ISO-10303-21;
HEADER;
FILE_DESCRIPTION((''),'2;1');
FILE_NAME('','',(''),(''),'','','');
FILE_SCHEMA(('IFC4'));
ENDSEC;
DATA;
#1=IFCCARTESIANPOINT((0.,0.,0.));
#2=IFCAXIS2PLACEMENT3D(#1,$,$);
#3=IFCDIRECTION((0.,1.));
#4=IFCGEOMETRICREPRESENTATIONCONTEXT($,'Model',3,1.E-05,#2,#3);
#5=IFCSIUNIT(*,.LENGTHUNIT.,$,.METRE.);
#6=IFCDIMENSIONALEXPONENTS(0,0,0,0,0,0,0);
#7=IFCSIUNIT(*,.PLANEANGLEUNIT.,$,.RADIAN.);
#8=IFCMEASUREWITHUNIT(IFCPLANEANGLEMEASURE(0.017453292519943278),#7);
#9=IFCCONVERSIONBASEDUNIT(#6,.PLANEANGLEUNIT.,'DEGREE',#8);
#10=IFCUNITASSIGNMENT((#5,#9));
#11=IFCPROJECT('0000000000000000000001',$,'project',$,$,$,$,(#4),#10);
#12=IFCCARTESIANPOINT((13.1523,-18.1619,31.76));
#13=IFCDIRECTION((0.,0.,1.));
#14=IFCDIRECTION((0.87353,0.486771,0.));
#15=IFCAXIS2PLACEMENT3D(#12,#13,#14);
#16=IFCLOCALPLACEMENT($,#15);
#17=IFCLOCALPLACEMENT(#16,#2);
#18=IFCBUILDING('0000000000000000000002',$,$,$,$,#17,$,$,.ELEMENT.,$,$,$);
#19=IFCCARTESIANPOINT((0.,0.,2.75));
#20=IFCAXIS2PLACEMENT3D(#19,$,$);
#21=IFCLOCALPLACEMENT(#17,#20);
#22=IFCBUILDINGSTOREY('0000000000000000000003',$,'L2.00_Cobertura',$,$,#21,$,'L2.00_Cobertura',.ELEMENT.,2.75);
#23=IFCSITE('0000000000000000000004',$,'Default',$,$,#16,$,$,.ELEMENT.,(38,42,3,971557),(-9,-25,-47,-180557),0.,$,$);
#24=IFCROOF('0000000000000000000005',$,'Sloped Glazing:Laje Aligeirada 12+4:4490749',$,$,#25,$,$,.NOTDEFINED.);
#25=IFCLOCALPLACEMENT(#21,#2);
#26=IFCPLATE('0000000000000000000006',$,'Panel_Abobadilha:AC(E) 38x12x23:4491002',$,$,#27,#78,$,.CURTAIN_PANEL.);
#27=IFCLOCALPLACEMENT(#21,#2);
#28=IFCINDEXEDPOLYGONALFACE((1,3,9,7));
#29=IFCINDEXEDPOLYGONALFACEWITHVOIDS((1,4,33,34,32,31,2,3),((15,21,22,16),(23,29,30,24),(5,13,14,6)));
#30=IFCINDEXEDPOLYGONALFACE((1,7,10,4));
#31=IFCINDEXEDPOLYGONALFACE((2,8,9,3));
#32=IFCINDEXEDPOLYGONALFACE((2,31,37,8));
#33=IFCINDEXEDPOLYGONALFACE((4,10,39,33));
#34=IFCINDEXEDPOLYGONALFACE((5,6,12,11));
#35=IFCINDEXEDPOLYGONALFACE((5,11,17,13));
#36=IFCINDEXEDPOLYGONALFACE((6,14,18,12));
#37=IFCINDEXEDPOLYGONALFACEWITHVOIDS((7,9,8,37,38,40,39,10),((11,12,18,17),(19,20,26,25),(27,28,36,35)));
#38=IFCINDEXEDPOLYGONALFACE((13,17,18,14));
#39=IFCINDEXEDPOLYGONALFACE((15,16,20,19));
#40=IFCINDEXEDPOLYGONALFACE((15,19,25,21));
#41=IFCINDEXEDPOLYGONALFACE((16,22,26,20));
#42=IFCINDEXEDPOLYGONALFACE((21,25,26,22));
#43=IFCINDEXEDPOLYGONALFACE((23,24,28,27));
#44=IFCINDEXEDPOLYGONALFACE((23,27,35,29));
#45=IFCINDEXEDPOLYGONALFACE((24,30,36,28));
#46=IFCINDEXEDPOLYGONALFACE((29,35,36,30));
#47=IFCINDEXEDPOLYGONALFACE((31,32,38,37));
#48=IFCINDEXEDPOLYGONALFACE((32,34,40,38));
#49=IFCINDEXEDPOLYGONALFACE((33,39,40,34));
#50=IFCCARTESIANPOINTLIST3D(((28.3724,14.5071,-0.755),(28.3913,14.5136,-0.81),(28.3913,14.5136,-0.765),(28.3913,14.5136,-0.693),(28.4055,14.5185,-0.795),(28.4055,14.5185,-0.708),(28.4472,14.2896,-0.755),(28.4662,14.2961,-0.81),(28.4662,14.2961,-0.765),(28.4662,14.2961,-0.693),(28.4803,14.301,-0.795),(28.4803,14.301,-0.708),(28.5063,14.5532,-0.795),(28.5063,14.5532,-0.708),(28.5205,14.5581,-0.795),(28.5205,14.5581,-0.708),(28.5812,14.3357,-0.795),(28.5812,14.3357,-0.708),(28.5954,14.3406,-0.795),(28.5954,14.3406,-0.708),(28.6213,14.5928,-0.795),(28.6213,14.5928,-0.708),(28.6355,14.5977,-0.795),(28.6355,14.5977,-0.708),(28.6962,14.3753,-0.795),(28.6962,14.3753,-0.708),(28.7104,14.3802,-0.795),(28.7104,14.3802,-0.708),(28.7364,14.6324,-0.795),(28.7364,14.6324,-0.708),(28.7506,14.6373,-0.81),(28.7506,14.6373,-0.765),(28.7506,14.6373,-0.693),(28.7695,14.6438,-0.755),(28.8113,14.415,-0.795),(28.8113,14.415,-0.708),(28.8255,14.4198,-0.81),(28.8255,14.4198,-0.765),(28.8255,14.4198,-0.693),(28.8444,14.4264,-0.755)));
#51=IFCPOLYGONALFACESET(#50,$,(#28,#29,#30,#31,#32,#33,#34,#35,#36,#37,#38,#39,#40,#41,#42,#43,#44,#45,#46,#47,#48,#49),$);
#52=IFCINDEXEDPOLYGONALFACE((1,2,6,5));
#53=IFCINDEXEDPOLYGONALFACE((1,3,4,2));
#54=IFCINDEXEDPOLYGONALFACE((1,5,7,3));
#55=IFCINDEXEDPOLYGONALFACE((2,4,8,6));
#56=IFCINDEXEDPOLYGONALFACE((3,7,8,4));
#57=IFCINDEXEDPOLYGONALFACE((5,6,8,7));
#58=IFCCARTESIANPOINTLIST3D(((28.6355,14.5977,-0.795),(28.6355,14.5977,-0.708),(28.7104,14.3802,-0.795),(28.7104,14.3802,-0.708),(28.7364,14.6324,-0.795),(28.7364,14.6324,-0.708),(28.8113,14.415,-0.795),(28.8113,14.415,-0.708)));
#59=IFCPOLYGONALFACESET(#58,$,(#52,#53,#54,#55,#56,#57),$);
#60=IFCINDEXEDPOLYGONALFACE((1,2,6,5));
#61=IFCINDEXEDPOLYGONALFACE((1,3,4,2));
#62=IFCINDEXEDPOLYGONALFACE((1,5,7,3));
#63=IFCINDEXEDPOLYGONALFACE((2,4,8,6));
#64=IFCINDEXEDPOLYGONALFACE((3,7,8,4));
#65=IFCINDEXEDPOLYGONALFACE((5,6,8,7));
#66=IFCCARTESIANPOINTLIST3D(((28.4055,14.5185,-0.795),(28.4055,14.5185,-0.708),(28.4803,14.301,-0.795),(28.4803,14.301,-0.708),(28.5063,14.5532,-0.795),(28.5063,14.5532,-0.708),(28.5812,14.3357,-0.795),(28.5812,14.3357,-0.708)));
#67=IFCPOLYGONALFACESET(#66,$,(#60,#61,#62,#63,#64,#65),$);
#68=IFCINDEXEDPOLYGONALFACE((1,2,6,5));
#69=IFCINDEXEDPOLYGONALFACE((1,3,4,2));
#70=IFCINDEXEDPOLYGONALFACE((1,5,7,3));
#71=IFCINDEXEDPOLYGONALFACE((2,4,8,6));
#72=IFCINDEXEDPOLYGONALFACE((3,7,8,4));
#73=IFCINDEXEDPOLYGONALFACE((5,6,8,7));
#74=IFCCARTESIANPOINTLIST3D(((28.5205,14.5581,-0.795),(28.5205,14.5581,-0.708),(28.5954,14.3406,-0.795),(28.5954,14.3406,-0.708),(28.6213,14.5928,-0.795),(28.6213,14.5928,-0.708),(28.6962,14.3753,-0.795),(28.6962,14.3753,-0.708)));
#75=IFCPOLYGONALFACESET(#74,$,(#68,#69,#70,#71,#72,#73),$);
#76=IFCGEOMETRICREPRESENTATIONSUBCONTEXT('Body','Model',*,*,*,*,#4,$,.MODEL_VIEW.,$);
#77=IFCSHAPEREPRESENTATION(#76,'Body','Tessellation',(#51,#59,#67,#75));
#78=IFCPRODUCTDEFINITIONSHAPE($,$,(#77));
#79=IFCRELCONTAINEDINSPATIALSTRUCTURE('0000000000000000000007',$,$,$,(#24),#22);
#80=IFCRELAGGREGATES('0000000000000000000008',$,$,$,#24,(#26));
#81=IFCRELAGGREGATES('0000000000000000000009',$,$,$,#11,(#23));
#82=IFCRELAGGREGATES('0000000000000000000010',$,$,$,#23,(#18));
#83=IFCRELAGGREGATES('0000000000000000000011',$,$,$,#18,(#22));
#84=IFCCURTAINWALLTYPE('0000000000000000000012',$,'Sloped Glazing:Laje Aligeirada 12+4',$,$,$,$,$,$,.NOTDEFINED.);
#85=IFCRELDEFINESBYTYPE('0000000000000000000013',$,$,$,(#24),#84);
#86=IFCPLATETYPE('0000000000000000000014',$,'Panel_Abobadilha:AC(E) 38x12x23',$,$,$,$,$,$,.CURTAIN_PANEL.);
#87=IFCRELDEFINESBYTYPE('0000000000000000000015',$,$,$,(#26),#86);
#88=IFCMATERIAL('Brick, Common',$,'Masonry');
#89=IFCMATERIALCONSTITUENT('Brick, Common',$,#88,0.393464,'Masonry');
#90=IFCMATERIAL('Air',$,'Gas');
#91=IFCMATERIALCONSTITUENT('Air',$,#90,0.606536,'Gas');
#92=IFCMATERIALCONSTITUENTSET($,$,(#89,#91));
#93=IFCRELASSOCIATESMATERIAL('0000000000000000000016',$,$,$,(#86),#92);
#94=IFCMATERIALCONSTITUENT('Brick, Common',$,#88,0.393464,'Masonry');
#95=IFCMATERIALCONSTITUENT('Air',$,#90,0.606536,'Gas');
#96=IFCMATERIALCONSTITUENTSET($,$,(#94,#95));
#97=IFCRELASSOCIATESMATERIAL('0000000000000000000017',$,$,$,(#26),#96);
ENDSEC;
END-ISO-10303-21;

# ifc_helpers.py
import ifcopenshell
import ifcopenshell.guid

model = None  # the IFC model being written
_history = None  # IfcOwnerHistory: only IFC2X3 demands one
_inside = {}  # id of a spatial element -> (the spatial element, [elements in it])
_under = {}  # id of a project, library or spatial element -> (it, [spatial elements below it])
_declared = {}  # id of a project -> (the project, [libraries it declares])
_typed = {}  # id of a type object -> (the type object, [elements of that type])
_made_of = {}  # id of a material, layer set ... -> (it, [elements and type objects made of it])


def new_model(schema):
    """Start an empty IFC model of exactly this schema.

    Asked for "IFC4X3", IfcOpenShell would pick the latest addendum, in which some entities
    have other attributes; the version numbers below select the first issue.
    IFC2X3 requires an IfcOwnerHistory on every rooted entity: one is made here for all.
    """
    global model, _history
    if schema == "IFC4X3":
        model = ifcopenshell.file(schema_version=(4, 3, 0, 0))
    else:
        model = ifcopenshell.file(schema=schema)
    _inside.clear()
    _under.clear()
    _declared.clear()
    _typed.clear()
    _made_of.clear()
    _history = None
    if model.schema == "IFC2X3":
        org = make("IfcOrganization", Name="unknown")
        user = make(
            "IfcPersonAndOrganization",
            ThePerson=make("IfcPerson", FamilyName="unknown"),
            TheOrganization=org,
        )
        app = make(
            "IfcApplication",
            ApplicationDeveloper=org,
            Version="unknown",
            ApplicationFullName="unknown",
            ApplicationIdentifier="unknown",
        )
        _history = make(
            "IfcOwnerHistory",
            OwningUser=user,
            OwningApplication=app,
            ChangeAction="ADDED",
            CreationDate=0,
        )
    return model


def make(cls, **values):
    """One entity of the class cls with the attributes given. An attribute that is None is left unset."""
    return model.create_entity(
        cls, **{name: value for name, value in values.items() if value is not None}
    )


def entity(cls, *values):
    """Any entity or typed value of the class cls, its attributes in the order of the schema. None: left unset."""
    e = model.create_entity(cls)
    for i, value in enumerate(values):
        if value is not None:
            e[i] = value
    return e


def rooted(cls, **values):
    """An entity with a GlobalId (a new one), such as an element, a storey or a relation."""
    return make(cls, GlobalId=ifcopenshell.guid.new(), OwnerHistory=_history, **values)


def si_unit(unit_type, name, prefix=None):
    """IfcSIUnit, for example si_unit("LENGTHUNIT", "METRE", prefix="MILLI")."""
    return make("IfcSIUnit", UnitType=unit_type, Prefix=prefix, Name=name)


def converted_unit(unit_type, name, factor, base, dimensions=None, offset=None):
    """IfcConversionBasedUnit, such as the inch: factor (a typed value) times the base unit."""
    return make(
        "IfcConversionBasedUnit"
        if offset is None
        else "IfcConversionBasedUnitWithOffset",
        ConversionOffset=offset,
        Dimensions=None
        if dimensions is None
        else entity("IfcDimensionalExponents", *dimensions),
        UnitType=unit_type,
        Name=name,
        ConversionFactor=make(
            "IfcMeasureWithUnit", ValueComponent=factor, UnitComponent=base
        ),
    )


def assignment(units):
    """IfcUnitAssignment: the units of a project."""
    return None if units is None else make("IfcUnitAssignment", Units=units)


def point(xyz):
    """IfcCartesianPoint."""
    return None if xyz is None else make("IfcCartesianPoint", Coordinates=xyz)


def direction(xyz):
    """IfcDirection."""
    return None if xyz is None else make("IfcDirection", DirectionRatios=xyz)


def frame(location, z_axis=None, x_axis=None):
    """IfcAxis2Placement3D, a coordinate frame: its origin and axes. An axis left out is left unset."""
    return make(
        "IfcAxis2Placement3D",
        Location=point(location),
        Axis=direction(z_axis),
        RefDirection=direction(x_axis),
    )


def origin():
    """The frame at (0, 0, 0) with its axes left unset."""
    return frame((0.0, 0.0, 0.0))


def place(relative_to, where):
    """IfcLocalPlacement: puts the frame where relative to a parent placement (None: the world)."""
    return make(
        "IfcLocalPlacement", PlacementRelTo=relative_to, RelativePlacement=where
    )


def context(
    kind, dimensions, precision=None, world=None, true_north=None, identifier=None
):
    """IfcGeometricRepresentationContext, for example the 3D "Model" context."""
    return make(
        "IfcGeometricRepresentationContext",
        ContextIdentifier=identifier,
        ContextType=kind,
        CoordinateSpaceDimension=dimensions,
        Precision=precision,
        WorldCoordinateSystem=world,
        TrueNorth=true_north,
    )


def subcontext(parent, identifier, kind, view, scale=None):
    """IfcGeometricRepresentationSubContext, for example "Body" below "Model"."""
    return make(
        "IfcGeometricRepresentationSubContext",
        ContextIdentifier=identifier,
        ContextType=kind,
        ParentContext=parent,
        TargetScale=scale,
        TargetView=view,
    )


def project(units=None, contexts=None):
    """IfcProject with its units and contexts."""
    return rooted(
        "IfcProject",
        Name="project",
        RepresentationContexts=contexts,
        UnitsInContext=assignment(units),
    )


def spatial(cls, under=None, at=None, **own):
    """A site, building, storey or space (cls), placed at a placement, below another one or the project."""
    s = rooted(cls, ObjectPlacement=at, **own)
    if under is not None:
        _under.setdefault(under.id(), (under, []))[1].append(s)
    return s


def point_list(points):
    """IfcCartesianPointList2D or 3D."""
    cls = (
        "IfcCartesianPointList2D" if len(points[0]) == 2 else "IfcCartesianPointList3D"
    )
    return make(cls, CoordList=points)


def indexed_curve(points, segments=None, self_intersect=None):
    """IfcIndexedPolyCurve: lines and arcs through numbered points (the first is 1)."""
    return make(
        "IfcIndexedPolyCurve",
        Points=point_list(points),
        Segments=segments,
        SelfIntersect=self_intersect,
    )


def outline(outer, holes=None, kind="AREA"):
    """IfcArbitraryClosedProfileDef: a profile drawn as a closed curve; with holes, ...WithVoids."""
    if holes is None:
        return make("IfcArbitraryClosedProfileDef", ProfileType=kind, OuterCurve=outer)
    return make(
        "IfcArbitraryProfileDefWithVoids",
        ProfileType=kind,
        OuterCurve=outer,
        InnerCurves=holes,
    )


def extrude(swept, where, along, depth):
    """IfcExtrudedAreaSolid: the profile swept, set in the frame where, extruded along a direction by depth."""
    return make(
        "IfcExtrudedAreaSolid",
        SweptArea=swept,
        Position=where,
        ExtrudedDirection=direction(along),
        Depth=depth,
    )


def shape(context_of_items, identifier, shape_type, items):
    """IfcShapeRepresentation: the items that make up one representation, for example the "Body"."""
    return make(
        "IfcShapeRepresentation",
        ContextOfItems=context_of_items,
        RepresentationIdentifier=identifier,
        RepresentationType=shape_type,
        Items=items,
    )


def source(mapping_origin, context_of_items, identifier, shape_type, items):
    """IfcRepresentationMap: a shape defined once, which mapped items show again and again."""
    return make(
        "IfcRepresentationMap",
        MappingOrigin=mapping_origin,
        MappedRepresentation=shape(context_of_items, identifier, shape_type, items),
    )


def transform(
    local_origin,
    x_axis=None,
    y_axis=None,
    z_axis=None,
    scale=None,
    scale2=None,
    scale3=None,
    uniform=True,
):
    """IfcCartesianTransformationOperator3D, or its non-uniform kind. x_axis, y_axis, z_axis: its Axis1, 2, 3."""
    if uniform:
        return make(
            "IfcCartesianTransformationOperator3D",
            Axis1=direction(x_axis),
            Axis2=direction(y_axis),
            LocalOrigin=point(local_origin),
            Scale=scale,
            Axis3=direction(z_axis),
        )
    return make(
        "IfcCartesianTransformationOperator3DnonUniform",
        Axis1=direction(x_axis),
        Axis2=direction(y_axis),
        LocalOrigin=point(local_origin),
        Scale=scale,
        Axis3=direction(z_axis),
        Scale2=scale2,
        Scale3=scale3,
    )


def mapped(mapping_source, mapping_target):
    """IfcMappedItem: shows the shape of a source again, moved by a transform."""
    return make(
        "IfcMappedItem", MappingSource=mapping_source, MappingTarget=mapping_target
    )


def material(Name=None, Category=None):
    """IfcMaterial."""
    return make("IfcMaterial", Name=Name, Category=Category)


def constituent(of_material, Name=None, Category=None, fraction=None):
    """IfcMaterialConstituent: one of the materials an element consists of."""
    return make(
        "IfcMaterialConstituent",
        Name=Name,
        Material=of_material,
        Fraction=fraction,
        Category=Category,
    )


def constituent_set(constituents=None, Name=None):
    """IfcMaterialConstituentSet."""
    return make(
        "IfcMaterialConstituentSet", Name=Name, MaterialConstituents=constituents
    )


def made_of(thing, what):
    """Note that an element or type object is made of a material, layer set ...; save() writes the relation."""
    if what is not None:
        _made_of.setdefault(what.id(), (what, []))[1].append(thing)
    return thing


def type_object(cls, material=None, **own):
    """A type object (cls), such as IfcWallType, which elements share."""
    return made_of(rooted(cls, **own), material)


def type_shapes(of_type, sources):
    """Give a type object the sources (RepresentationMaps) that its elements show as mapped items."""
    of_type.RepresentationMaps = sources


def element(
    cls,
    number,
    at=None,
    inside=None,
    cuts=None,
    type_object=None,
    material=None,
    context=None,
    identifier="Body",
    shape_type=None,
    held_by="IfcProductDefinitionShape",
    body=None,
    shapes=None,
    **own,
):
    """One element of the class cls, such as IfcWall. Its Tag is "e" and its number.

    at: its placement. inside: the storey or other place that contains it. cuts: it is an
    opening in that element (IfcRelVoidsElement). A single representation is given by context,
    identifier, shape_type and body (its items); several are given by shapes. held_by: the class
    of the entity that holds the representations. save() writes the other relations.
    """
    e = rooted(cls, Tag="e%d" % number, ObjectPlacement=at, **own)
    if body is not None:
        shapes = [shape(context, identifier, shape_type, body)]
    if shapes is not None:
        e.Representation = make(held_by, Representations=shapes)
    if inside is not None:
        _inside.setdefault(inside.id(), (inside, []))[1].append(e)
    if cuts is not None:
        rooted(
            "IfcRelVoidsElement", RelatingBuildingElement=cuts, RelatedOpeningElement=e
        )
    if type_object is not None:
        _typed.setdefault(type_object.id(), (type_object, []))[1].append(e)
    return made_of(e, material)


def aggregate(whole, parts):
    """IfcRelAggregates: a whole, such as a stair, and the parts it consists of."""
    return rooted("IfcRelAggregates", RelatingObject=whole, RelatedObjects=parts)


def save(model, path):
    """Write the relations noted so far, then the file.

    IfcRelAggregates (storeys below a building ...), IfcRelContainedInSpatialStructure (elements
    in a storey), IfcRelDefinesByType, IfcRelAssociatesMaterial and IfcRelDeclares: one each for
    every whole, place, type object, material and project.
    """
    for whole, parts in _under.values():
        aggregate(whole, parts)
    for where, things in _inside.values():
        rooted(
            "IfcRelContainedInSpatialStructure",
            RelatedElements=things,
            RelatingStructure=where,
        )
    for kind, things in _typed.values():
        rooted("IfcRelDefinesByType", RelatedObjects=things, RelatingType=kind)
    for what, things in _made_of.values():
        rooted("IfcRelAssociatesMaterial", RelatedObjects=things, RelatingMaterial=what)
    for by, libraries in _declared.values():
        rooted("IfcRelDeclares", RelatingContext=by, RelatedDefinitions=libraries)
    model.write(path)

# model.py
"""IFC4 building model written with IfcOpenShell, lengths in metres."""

from ifc_helpers import new_model, entity, si_unit, converted_unit, direction, frame, origin, place, context, subcontext, project, spatial, indexed_curve, outline, extrude, source, transform, mapped, material, constituent, constituent_set, type_object, type_shapes, element, aggregate, save


model = new_model("IFC4")

# Units and contexts
model_context = context("Model", 3, precision=1e-05, world=origin(), true_north=direction((0.0, 1.0)))
body_context = subcontext(model_context, "Body", "Model", "MODEL_VIEW")
ifc_project = project(units=[si_unit("LENGTHUNIT", "METRE"), converted_unit("PLANEANGLEUNIT", "DEGREE", entity("IfcPlaneAngleMeasure", 0.017453292519943278), si_unit("PLANEANGLEUNIT", "RADIAN"), dimensions=[0, 0, 0, 0, 0, 0, 0])], contexts=[model_context])

# Site, building, storey
site_placement = place(None, frame((13.1523, -18.1619, 31.76), z_axis=(0.0, 0.0, 1.0), x_axis=(0.87353, 0.486771, 0.0)))
site = spatial("IfcSite", under=ifc_project, at=site_placement, Name="Default", CompositionType="ELEMENT", RefLatitude=(38, 42, 3, 971557), RefLongitude=(-9, -25, -47, -180557), RefElevation=0.0)
building_placement = place(site_placement, origin())
building = spatial("IfcBuilding", under=site, at=building_placement, CompositionType="ELEMENT")
storey_placement = place(building_placement, frame((0.0, 0.0, 2.75)))
storey = spatial("IfcBuildingStorey", under=building, at=storey_placement, Name="L2.00_Cobertura", LongName="L2.00_Cobertura", CompositionType="ELEMENT", Elevation=2.75)

# Roof, plate
curtain_wall_type = type_object("IfcCurtainWallType", Name="Sloped Glazing:Laje Aligeirada 12+4", PredefinedType="NOTDEFINED")
roof_placement = place(storey_placement, frame((0.0, 0.0, -2.75)))
roof = element("IfcRoof", 1, at=roof_placement, inside=storey, type_object=curtain_wall_type, Name="Sloped Glazing:Laje Aligeirada 12+4:4490749", PredefinedType="NOTDEFINED")
ifc_material_1 = material(Name="Brick, Common", Category="Masonry")
ifc_material_2 = material(Name="Air", Category="Gas")
ifc_constituent_1 = constituent(ifc_material_1, Name="Brick, Common", Category="Masonry", fraction=0.393464)
ifc_constituent_2 = constituent(ifc_material_2, Name="Air", Category="Gas", fraction=0.606536)
ifc_constituent_set_1 = constituent_set(constituents=[ifc_constituent_1, ifc_constituent_2])
plate_type_1 = type_object("IfcPlateType", Name="Panel_Abobadilha:AC(E) 38x12x23", PredefinedType="CURTAIN_PANEL", material=ifc_constituent_set_1)
shared_shape_1 = source(origin(), body_context, "Body", "SweptSolid", [
    extrude(outline(indexed_curve([(-0.19, -0.0543), (0.19, -0.0543), (0.19, -0.0093), (0.21, 0.0007), (0.19, 0.0628), (-0.19, 0.0628), (-0.21, 0.0007), (-0.19, -0.0093), (-0.19, -0.0543)], self_intersect=False), holes=[indexed_curve([(-0.0683, 0.0477), (-0.0683, -0.0393), (-0.175, -0.0393), (-0.175, 0.0477), (-0.0683, 0.0477)], self_intersect=False), indexed_curve([(0.0533, 0.0477), (0.0533, -0.0393), (-0.0533, -0.0393), (-0.0533, 0.0477), (0.0533, 0.0477)], self_intersect=False), indexed_curve([(0.175, 0.0477), (0.175, -0.0393), (0.0683, -0.0393), (0.0683, 0.0477), (0.175, 0.0477)], self_intersect=False)]), frame((0.0, 0.0543, 0.0)), (0.0, 0.0, 1.0), 0.23),
    extrude(outline(indexed_curve([(-0.0533, -0.0435), (0.0533, -0.0435), (0.0533, 0.0435), (-0.0533, 0.0435), (-0.0533, -0.0435)], self_intersect=False)), frame((0.1217, 0.0585, 0.0), z_axis=(0.0, 0.0, 1.0), x_axis=(-1.0, 0.0, 0.0)), (0.0, 0.0, 1.0), 0.23),
    extrude(outline(indexed_curve([(-0.0533, -0.0435), (0.0533, -0.0435), (0.0533, 0.0435), (-0.0533, 0.0435), (-0.0533, -0.0435)], self_intersect=False)), frame((-0.1217, 0.0585, 0.0), z_axis=(0.0, 0.0, 1.0), x_axis=(-1.0, 0.0, 0.0)), (0.0, 0.0, 1.0), 0.23),
    extrude(outline(indexed_curve([(-0.0533, -0.0435), (0.0533, -0.0435), (0.0533, 0.0435), (-0.0533, 0.0435), (-0.0533, -0.0435)], self_intersect=False)), frame((0.0, 0.0585, 0.0), z_axis=(0.0, 0.0, 1.0), x_axis=(-1.0, 0.0, 0.0)), (0.0, 0.0, 1.0), 0.23),
])
type_shapes(plate_type_1, [shared_shape_1])
ifc_constituent_3 = constituent(ifc_material_1, Name="Brick, Common", Category="Masonry", fraction=0.393464)
ifc_constituent_4 = constituent(ifc_material_2, Name="Air", Category="Gas", fraction=0.606536)
ifc_constituent_set_2 = constituent_set(constituents=[ifc_constituent_3, ifc_constituent_4])
plate_1_placement = place(roof_placement, frame((28.5709, 14.5755, 1.94), z_axis=(0.325568, -0.945519, 0.0), x_axis=(0.945519, 0.325568, 0.0)))
plate_1 = element("IfcPlate", 2, at=plate_1_placement, type_object=plate_type_1, material=ifc_constituent_set_2, Name="Panel_Abobadilha:AC(E) 38x12x23:4491002", PredefinedType="CURTAIN_PANEL", context=body_context, shape_type="MappedRepresentation", body=[
    mapped(shared_shape_1, transform((0.0, 0.0, 0.0), scale=1.0)),
])
aggregate(roof, [plate_1])

save(model, "model.ifc")
